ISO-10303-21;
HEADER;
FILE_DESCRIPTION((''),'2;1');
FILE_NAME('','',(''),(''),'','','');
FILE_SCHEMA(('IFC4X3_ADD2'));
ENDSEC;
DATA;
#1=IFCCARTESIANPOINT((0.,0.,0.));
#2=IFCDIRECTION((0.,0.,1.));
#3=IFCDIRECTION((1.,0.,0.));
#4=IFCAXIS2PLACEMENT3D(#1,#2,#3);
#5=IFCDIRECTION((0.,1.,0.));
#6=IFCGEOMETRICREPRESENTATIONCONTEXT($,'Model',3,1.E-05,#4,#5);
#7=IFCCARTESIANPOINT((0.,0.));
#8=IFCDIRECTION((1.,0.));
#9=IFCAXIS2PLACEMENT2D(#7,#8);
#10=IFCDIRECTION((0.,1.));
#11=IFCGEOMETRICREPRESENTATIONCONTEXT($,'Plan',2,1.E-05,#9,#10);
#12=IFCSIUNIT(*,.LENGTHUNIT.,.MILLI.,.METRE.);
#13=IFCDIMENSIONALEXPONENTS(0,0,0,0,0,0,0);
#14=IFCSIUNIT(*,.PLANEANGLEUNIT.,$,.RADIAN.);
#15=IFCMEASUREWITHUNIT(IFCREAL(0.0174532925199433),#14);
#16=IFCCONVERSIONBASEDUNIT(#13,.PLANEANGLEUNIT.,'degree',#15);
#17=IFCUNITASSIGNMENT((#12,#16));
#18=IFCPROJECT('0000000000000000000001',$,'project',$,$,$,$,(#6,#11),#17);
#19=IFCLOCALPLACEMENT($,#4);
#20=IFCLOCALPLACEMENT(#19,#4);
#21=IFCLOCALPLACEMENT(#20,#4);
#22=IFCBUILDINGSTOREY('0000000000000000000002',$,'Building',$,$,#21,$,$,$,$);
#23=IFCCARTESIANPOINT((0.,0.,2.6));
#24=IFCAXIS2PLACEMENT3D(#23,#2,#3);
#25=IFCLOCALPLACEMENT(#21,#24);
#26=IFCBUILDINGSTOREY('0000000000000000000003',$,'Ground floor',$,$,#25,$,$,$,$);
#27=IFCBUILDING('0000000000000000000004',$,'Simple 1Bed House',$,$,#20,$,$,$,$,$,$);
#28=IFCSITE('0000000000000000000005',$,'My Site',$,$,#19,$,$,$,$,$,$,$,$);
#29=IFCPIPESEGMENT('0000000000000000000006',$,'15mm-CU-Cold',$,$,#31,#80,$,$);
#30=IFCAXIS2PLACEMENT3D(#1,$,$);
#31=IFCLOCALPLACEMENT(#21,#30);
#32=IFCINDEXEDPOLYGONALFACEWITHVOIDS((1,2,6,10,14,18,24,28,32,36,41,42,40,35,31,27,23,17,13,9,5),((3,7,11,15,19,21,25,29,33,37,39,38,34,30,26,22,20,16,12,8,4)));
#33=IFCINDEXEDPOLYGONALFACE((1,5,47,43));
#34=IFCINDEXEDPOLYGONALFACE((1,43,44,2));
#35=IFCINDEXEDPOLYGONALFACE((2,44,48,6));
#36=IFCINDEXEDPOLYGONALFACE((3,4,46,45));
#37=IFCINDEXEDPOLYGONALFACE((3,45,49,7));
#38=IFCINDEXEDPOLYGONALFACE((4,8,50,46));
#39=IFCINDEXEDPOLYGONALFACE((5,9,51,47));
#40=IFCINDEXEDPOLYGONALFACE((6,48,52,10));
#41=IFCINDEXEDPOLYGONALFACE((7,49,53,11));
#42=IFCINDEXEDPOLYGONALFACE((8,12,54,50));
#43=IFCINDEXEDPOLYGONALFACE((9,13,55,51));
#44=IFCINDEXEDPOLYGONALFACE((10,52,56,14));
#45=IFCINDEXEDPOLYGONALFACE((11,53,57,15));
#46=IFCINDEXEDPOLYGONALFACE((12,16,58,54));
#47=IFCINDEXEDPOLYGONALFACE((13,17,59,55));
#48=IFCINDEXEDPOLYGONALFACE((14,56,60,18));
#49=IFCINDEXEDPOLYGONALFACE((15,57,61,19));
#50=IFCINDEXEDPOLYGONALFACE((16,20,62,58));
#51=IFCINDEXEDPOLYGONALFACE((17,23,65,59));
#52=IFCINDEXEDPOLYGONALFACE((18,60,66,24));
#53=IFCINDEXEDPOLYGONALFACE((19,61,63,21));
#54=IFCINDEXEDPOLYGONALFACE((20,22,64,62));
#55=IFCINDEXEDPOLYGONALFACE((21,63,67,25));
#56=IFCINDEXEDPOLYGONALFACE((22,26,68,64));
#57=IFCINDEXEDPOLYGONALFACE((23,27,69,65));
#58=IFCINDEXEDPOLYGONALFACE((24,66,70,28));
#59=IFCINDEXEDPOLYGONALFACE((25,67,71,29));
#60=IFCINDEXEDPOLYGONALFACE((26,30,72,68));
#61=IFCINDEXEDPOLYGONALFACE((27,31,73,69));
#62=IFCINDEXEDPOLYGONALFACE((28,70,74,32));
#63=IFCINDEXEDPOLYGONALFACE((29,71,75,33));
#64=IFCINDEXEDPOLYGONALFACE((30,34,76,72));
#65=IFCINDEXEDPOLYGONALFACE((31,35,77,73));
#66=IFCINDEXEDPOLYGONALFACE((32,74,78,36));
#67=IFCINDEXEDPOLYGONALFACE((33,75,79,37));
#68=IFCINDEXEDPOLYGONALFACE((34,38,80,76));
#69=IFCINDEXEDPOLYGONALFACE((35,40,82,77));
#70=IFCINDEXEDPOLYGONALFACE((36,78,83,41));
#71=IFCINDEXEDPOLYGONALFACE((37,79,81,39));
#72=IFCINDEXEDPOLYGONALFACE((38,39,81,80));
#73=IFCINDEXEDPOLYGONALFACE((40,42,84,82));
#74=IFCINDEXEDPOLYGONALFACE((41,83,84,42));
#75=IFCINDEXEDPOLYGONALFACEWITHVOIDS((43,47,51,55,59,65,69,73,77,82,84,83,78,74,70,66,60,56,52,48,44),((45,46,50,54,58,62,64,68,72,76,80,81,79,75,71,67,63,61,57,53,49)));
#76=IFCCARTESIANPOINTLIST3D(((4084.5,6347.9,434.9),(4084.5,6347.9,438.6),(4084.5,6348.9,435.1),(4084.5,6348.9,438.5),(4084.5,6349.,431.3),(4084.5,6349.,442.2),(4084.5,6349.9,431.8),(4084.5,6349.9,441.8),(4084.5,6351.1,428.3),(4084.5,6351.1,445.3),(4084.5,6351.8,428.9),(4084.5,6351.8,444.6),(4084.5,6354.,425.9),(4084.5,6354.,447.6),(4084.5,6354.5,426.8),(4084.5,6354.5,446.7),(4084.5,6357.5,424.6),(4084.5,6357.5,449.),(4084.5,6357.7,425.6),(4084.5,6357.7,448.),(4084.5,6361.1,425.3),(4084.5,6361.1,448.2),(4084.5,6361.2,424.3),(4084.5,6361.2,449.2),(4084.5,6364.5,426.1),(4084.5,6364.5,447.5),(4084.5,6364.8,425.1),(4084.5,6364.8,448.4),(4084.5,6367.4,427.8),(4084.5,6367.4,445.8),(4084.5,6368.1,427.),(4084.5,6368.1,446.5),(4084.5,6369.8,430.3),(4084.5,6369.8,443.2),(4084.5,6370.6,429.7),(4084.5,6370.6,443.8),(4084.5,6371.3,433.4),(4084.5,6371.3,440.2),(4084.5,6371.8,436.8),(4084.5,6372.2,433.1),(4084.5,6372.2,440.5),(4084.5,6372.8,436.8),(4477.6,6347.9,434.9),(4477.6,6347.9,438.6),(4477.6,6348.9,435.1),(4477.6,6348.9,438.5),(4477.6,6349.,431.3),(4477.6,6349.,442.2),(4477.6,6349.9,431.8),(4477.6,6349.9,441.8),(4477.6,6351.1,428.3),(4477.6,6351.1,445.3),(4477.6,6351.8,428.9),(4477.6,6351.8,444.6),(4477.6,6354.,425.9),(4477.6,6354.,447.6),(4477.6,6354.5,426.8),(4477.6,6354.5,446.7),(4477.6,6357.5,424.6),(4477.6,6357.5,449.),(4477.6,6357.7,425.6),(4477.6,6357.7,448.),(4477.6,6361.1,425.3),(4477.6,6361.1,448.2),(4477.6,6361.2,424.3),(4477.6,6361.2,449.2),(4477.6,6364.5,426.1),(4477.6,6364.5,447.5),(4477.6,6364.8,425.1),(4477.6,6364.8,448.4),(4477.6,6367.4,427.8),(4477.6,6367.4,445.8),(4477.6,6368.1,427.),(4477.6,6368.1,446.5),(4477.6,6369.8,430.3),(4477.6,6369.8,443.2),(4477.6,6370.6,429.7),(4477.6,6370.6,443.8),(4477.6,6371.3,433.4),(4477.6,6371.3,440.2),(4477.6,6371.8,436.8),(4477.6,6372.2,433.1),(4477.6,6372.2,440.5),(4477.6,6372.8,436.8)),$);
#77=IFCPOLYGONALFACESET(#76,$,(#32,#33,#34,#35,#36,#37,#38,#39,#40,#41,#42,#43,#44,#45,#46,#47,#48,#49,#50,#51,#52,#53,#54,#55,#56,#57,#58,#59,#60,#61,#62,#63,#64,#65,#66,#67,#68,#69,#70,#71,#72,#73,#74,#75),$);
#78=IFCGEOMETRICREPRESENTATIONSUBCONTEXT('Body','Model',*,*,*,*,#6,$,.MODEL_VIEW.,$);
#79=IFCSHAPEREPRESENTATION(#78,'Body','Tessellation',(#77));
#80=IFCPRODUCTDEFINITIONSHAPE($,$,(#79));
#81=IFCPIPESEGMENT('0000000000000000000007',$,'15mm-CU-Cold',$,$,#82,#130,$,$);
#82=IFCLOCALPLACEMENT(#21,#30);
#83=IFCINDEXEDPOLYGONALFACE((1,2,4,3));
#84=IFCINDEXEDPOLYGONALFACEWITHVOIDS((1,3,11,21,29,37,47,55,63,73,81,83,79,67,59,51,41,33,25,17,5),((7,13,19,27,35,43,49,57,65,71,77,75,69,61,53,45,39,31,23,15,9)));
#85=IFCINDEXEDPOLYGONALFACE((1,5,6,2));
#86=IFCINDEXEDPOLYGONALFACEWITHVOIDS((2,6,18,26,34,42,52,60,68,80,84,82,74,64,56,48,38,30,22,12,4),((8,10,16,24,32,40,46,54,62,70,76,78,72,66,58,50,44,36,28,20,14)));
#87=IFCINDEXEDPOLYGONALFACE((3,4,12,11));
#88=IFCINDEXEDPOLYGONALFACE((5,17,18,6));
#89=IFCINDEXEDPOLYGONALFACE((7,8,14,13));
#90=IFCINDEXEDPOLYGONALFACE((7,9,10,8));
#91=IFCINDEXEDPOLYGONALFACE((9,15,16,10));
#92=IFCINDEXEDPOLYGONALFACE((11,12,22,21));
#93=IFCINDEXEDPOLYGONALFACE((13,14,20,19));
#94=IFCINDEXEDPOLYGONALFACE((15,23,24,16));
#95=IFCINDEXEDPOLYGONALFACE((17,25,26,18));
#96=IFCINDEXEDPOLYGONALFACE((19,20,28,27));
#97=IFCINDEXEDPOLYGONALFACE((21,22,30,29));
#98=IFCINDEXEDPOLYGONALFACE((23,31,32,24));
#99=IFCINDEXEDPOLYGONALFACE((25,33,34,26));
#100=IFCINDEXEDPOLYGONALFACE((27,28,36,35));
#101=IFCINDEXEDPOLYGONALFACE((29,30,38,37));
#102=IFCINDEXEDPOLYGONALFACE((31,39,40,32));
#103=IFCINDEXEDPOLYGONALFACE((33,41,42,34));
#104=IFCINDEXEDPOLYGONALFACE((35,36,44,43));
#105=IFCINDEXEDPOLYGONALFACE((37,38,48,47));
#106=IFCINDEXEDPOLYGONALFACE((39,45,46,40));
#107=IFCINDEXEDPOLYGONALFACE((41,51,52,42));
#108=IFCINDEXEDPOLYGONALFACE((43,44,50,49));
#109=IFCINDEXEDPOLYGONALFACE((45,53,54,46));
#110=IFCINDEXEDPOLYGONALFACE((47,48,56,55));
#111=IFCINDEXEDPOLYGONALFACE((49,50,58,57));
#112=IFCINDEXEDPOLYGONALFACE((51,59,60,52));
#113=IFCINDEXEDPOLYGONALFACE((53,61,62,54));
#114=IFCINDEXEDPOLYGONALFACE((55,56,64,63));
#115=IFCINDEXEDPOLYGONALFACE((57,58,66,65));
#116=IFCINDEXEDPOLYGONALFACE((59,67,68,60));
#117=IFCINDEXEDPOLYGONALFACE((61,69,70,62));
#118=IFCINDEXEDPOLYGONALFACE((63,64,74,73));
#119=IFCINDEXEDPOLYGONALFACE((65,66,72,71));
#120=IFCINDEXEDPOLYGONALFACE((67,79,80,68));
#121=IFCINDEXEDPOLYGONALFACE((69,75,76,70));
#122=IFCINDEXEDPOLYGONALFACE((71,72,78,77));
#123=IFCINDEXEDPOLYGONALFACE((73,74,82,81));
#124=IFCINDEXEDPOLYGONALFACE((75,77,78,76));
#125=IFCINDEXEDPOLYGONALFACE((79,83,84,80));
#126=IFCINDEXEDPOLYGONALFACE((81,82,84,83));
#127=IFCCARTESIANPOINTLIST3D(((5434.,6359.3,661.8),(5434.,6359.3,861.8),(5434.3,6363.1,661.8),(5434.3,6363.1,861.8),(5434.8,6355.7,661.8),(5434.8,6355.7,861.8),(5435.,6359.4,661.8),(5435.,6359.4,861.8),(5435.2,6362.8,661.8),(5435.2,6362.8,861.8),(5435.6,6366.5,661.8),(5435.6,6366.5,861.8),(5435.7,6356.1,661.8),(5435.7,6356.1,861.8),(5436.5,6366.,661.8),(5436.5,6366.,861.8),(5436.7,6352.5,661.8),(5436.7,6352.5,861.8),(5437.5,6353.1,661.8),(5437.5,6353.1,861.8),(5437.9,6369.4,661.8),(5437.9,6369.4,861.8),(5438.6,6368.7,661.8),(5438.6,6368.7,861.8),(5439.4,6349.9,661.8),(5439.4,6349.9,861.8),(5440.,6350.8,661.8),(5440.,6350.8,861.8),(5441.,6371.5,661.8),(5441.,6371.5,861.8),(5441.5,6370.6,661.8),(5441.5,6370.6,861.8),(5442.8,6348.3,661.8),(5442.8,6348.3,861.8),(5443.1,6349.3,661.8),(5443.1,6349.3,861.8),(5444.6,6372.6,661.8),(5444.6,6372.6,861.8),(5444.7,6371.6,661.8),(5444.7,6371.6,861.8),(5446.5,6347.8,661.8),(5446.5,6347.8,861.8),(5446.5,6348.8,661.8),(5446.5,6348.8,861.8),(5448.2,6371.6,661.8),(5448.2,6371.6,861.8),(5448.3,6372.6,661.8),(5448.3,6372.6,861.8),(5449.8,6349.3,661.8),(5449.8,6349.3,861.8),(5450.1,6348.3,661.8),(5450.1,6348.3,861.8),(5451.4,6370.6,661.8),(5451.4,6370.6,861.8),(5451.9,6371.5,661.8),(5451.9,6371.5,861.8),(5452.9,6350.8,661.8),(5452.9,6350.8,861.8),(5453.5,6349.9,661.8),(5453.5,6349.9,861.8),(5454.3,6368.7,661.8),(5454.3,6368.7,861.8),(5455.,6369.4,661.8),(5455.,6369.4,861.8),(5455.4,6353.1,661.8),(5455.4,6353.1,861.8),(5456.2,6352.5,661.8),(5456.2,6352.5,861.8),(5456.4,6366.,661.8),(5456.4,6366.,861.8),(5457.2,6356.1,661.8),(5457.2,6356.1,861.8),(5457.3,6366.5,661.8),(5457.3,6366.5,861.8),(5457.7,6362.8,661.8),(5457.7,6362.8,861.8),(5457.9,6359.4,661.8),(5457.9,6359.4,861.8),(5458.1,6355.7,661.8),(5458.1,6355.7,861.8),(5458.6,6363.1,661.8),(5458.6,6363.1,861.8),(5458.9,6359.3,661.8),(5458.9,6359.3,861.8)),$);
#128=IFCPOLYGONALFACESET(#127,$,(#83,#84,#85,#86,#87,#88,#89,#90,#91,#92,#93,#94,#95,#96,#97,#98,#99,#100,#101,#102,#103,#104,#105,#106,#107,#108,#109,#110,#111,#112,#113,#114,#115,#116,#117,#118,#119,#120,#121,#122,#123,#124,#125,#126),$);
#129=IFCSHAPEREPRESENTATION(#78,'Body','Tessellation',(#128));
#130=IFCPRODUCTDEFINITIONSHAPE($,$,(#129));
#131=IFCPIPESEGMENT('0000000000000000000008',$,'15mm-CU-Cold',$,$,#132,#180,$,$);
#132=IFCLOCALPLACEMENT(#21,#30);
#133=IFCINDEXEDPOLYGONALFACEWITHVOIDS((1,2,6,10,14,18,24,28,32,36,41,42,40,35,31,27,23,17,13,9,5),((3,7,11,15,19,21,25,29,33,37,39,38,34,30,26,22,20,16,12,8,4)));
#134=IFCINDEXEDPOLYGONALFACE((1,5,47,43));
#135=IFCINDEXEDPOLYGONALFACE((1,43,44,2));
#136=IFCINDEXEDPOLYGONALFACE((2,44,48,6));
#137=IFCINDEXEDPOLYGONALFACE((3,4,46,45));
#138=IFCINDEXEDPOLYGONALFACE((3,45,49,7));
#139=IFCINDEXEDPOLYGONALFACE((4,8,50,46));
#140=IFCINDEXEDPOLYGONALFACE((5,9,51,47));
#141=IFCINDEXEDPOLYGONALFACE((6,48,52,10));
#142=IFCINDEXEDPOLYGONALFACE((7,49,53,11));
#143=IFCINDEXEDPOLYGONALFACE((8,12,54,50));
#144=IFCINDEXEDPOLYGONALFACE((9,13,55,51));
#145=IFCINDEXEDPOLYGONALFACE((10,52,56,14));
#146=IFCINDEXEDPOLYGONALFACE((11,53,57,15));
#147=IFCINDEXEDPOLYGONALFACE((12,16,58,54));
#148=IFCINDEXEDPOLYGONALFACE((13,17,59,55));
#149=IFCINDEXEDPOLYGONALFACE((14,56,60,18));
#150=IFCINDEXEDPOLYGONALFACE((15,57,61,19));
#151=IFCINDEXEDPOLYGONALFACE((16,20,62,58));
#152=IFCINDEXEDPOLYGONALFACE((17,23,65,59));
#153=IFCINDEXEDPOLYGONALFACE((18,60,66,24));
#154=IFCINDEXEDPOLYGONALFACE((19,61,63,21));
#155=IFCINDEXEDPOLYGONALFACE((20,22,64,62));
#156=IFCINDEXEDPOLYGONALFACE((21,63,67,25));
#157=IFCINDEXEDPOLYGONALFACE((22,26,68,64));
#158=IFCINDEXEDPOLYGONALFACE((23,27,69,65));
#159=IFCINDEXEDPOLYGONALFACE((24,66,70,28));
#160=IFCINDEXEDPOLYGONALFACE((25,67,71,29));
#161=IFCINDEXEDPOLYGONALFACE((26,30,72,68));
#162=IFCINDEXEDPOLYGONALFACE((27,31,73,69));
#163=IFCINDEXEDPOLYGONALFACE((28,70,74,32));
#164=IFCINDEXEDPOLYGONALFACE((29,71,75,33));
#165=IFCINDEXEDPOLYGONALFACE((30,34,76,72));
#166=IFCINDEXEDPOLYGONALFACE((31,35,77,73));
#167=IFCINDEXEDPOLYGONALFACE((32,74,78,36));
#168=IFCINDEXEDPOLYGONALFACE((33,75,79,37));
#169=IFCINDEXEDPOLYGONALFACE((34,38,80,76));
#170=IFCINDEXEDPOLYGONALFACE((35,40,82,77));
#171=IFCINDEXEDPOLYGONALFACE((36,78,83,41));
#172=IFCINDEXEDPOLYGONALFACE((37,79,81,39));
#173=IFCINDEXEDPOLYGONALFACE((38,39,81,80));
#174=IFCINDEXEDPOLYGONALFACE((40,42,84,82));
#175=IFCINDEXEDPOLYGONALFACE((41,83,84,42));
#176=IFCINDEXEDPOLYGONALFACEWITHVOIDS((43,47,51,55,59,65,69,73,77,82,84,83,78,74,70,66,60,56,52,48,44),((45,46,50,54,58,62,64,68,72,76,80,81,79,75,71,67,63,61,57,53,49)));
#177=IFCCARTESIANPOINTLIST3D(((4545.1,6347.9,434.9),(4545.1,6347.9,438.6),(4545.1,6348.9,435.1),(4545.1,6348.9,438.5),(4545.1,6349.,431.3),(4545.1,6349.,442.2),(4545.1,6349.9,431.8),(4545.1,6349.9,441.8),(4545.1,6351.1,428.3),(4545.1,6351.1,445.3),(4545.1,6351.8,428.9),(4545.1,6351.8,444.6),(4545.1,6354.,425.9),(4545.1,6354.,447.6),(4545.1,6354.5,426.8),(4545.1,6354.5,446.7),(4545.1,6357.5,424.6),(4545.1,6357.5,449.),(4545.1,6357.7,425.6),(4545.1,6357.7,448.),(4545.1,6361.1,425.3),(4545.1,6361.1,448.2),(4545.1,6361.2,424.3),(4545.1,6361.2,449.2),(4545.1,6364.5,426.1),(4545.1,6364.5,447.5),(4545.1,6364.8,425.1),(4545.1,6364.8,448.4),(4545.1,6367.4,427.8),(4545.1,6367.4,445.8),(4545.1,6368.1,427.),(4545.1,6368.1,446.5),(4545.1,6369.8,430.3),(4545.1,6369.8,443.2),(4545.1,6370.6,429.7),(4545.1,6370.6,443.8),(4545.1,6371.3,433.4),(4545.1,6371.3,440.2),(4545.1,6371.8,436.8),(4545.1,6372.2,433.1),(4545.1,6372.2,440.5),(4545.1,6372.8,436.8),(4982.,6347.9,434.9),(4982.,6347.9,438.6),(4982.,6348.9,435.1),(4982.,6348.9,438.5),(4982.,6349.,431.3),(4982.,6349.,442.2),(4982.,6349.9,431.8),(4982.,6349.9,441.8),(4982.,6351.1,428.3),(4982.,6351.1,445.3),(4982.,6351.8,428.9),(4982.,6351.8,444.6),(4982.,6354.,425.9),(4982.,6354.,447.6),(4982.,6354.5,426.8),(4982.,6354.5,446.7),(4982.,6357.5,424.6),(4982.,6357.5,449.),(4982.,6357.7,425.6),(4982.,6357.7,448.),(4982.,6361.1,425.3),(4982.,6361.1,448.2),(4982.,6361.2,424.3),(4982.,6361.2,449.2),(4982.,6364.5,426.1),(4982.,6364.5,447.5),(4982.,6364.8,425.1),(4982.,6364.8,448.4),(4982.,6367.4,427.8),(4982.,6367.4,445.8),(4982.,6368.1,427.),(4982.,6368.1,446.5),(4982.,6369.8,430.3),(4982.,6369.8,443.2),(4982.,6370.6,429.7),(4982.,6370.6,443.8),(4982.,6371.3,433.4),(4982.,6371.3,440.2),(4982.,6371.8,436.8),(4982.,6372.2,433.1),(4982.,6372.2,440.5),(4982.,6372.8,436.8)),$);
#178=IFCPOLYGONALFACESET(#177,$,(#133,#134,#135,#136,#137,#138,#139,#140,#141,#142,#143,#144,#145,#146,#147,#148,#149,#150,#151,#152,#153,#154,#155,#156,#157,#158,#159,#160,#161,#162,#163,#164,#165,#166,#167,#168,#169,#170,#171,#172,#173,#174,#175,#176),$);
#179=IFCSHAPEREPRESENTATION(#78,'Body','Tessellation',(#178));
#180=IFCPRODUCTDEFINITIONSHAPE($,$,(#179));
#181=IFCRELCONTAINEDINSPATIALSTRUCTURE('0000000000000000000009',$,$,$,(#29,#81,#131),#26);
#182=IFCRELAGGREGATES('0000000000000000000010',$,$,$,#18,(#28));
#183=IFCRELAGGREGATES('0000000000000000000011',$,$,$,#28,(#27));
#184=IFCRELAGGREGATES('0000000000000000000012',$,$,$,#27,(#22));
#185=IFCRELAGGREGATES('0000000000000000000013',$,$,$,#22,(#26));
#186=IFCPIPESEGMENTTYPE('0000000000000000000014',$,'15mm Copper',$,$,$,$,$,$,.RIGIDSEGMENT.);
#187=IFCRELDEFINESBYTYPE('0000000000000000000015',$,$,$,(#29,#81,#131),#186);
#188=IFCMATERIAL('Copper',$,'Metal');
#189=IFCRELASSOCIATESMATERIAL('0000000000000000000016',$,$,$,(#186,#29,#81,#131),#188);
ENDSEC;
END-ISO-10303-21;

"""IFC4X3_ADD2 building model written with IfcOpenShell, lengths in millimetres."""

from ifc_helpers import new_model, entity, si_unit, converted_unit, direction, frame, origin_with_axes, origin_2d_with_axis, place, context, subcontext, project, spatial, hollow_circle, extrude, material, material_profile, profile_set, profile_usage, type_object, element, save


model = new_model("IFC4X3_ADD2")

# Units and contexts
model_context = context("Model", 3, precision=1e-05, world=origin_with_axes(), true_north=direction((0.0, 1.0, 0.0)))
plan_context = context("Plan", 2, precision=1e-05, world=origin_2d_with_axis(), true_north=direction((0.0, 1.0)))
body_context_1 = subcontext(model_context, "Body", "Model", "MODEL_VIEW")
ifc_project = project(units=[si_unit("LENGTHUNIT", "METRE", prefix="MILLI"), converted_unit("PLANEANGLEUNIT", "degree", entity("IfcReal", 0.0174532925199433), si_unit("PLANEANGLEUNIT", "RADIAN"), dimensions=[0, 0, 0, 0, 0, 0, 0])], contexts=[model_context, plan_context])

# Site, building, storeys
site_placement = place(None, origin_with_axes())
site = spatial("IfcSite", under=ifc_project, at=site_placement, Name="My Site")
building_placement = place(site_placement, origin_with_axes())
building = spatial("IfcBuilding", under=site, at=building_placement, Name="Simple 1Bed House")
storey_1_placement = place(building_placement, origin_with_axes())
storey_1 = spatial("IfcBuildingStorey", under=building, at=storey_1_placement, Name="Building")
storey_2_placement = place(storey_1_placement, frame((0.0, 0.0, 2.6), z_axis=(0.0, 0.0, 1.0), x_axis=(1.0, 0.0, 0.0)))
storey_2 = spatial("IfcBuildingStorey", under=storey_1, at=storey_2_placement, Name="Ground floor")

# Pipe segments
ifc_material_1 = material(Name="Copper", Category="Metal")
ifc_material_profile = material_profile(ifc_material_1, hollow_circle(Radius=12.5, WallThickness=1.0))
ifc_profile_set = profile_set([ifc_material_profile])
pipe_segment_type = type_object("IfcPipeSegmentType", Name="15mm Copper", PredefinedType="RIGIDSEGMENT", material=ifc_profile_set)
ifc_profile_usage_1 = profile_usage(ifc_profile_set, cardinal=5)
pipe_segment_1_placement = place(storey_2_placement, frame((4084.5, 6360.3, 434.2), z_axis=(1.0, 0.0, 0.0), x_axis=(0.0, 1.0, 0.0)))
element("IfcPipeSegment", 1, at=pipe_segment_1_placement, inside=storey_2, type_object=pipe_segment_type, material=ifc_profile_usage_1, Name="15mm-CU-Cold", context=body_context_1, shape_type="SweptSolid", body=[
    extrude(hollow_circle(Radius=12.5, WallThickness=1.0), origin_with_axes(), (0.0, 0.0, 1.0), 393.1),
])
ifc_profile_usage_2 = profile_usage(ifc_profile_set, cardinal=5)
pipe_segment_2_placement = place(storey_2_placement, frame((5446.5, 6360.3, 659.2), z_axis=(0.0, 0.0, 1.0), x_axis=(0.0, -1.0, 0.0)))
element("IfcPipeSegment", 2, at=pipe_segment_2_placement, inside=storey_2, type_object=pipe_segment_type, material=ifc_profile_usage_2, Name="15mm-CU-Cold", context=body_context_1, shape_type="SweptSolid", body=[
    extrude(hollow_circle(Radius=12.5, WallThickness=1.0), origin_with_axes(), (0.0, 0.0, 1.0), 200.0),
])
ifc_profile_usage_3 = profile_usage(ifc_profile_set, cardinal=5)
pipe_segment_3_placement = place(storey_2_placement, frame((4545.1, 6360.3, 434.2), z_axis=(1.0, 0.0, 0.0), x_axis=(0.0, 1.0, 0.0)))
element("IfcPipeSegment", 3, at=pipe_segment_3_placement, inside=storey_2, type_object=pipe_segment_type, material=ifc_profile_usage_3, Name="15mm-CU-Cold", context=body_context_1, shape_type="SweptSolid", body=[
    extrude(hollow_circle(Radius=12.5, WallThickness=1.0), origin_with_axes(), (0.0, 0.0, 1.0), 436.9),
])

save(model, "model.ifc")
